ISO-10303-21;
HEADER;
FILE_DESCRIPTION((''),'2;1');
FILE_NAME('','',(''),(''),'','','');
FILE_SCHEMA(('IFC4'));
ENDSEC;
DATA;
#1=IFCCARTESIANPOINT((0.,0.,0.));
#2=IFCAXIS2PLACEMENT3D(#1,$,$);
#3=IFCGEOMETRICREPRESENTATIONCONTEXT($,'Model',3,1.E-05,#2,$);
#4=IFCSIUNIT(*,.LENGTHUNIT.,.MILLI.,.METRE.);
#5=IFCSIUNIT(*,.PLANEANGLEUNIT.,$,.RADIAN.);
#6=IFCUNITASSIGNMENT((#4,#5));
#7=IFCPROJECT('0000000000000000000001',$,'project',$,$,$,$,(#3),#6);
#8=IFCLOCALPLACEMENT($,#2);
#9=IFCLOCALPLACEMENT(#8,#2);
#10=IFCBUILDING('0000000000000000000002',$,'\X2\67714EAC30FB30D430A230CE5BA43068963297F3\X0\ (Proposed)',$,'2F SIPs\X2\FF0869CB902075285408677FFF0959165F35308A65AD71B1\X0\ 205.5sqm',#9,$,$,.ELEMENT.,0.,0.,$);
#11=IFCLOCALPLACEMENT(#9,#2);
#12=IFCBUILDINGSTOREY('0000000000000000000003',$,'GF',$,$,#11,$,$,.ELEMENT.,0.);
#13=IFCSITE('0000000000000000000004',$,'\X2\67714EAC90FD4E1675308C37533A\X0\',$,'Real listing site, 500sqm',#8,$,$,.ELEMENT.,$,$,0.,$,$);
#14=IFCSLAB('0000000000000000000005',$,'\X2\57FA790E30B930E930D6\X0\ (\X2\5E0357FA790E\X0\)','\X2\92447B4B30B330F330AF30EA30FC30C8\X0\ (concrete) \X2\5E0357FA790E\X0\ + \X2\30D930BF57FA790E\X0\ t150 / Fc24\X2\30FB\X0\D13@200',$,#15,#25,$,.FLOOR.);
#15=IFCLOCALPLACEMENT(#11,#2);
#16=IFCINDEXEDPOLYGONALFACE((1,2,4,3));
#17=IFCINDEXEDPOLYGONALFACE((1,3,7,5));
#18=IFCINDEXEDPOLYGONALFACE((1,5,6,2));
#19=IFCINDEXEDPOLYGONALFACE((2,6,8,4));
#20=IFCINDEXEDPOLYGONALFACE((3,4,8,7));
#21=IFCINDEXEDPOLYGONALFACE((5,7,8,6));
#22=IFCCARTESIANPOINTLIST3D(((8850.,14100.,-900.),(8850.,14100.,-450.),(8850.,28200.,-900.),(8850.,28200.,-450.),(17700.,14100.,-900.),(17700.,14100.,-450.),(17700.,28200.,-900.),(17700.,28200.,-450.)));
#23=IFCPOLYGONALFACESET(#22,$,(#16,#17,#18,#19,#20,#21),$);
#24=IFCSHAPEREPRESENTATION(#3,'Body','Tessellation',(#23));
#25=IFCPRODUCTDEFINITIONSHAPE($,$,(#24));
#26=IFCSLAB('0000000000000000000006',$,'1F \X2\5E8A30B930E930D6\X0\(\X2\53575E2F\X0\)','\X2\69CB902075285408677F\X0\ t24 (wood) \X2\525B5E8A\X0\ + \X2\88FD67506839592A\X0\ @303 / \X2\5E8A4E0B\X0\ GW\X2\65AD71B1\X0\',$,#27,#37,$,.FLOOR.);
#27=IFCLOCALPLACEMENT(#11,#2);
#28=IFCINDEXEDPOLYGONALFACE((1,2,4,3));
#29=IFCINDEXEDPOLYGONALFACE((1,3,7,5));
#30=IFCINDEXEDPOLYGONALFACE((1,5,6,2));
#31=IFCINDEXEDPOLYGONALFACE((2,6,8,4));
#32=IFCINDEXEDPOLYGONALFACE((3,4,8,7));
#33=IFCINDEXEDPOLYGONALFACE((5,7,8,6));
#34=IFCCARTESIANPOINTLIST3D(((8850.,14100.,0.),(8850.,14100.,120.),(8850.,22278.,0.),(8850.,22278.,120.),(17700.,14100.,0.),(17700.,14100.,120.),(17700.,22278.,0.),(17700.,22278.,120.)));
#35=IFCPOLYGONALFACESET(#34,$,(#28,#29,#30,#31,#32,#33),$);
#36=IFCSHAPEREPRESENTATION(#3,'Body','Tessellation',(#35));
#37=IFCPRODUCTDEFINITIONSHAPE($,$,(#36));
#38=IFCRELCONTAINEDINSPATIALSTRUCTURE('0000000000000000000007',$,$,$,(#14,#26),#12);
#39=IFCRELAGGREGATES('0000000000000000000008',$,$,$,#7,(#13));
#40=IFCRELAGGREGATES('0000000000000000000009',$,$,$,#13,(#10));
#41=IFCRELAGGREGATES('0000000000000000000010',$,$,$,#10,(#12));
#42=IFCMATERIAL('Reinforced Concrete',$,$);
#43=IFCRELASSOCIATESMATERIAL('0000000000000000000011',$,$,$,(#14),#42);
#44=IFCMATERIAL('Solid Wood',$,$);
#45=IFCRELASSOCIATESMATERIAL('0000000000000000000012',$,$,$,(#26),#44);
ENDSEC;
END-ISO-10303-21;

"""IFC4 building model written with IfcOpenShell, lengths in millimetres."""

from ifc_helpers import new_model, si_unit, frame, frame_2d, origin, place, context, project, spatial, rectangle, extrude, material, element, save


model = new_model("IFC4")

# Units and contexts
model_context = context("Model", 3, precision=1e-05, world=origin())
ifc_project = project(units=[si_unit("LENGTHUNIT", "METRE", prefix="MILLI"), si_unit("PLANEANGLEUNIT", "RADIAN")], contexts=[model_context])

# Site, building, storey
site_placement = place(None, origin())
site = spatial("IfcSite", under=ifc_project, at=site_placement, Name="東京都世田谷区", ObjectType="Real listing site, 500sqm", CompositionType="ELEMENT", RefElevation=0.0)
building_placement = place(site_placement, origin())
building = spatial("IfcBuilding", under=site, at=building_placement, Name="東京・ピアノ室と防音 (Proposed)", ObjectType="2F SIPs（構造用合板）外張り断熱 205.5sqm", CompositionType="ELEMENT", ElevationOfRefHeight=0.0, ElevationOfTerrain=0.0)
storey_placement = place(building_placement, origin())
storey = spatial("IfcBuildingStorey", under=building, at=storey_placement, Name="GF", CompositionType="ELEMENT", Elevation=0.0)

# Shared definitions
ifc_material_1 = material(Name="Solid Wood")

# Slabs
ifc_material_2 = material(Name="Reinforced Concrete")
slab_1_placement = place(storey_placement, frame((4425.0, 7050.0, -450.0)))
element("IfcSlab", 1, at=slab_1_placement, inside=storey, material=ifc_material_2, Name="基礎スラブ (布基礎)", Description="鉄筋コンクリート (concrete) 布基礎 + ベタ基礎 t150 / Fc24・D13@200", PredefinedType="FLOOR", context=model_context, shape_type="SweptSolid", body=[
    extrude(rectangle(XDim=8850.0, YDim=14100.0, at=frame_2d((4425.0, 7050.0))), frame((4425.0, 7050.0, -450.0)), (0.0, 0.0, 1.0), 450.0),
])
slab_2_placement = place(storey_placement, frame((4425.0, 7050.0, 0.0)))
element("IfcSlab", 2, at=slab_2_placement, inside=storey, material=ifc_material_1, Name="1F 床スラブ(南帯)", Description="構造用合板 t24 (wood) 剛床 + 製材根太 @303 / 床下 GW断熱", PredefinedType="FLOOR", context=model_context, shape_type="SweptSolid", body=[
    extrude(rectangle(XDim=8850.0, YDim=8178.0, at=frame_2d((4425.0, 4089.0))), frame((4425.0, 7050.0, 0.0)), (0.0, 0.0, 1.0), 120.0),
])

save(model, "model.ifc")
